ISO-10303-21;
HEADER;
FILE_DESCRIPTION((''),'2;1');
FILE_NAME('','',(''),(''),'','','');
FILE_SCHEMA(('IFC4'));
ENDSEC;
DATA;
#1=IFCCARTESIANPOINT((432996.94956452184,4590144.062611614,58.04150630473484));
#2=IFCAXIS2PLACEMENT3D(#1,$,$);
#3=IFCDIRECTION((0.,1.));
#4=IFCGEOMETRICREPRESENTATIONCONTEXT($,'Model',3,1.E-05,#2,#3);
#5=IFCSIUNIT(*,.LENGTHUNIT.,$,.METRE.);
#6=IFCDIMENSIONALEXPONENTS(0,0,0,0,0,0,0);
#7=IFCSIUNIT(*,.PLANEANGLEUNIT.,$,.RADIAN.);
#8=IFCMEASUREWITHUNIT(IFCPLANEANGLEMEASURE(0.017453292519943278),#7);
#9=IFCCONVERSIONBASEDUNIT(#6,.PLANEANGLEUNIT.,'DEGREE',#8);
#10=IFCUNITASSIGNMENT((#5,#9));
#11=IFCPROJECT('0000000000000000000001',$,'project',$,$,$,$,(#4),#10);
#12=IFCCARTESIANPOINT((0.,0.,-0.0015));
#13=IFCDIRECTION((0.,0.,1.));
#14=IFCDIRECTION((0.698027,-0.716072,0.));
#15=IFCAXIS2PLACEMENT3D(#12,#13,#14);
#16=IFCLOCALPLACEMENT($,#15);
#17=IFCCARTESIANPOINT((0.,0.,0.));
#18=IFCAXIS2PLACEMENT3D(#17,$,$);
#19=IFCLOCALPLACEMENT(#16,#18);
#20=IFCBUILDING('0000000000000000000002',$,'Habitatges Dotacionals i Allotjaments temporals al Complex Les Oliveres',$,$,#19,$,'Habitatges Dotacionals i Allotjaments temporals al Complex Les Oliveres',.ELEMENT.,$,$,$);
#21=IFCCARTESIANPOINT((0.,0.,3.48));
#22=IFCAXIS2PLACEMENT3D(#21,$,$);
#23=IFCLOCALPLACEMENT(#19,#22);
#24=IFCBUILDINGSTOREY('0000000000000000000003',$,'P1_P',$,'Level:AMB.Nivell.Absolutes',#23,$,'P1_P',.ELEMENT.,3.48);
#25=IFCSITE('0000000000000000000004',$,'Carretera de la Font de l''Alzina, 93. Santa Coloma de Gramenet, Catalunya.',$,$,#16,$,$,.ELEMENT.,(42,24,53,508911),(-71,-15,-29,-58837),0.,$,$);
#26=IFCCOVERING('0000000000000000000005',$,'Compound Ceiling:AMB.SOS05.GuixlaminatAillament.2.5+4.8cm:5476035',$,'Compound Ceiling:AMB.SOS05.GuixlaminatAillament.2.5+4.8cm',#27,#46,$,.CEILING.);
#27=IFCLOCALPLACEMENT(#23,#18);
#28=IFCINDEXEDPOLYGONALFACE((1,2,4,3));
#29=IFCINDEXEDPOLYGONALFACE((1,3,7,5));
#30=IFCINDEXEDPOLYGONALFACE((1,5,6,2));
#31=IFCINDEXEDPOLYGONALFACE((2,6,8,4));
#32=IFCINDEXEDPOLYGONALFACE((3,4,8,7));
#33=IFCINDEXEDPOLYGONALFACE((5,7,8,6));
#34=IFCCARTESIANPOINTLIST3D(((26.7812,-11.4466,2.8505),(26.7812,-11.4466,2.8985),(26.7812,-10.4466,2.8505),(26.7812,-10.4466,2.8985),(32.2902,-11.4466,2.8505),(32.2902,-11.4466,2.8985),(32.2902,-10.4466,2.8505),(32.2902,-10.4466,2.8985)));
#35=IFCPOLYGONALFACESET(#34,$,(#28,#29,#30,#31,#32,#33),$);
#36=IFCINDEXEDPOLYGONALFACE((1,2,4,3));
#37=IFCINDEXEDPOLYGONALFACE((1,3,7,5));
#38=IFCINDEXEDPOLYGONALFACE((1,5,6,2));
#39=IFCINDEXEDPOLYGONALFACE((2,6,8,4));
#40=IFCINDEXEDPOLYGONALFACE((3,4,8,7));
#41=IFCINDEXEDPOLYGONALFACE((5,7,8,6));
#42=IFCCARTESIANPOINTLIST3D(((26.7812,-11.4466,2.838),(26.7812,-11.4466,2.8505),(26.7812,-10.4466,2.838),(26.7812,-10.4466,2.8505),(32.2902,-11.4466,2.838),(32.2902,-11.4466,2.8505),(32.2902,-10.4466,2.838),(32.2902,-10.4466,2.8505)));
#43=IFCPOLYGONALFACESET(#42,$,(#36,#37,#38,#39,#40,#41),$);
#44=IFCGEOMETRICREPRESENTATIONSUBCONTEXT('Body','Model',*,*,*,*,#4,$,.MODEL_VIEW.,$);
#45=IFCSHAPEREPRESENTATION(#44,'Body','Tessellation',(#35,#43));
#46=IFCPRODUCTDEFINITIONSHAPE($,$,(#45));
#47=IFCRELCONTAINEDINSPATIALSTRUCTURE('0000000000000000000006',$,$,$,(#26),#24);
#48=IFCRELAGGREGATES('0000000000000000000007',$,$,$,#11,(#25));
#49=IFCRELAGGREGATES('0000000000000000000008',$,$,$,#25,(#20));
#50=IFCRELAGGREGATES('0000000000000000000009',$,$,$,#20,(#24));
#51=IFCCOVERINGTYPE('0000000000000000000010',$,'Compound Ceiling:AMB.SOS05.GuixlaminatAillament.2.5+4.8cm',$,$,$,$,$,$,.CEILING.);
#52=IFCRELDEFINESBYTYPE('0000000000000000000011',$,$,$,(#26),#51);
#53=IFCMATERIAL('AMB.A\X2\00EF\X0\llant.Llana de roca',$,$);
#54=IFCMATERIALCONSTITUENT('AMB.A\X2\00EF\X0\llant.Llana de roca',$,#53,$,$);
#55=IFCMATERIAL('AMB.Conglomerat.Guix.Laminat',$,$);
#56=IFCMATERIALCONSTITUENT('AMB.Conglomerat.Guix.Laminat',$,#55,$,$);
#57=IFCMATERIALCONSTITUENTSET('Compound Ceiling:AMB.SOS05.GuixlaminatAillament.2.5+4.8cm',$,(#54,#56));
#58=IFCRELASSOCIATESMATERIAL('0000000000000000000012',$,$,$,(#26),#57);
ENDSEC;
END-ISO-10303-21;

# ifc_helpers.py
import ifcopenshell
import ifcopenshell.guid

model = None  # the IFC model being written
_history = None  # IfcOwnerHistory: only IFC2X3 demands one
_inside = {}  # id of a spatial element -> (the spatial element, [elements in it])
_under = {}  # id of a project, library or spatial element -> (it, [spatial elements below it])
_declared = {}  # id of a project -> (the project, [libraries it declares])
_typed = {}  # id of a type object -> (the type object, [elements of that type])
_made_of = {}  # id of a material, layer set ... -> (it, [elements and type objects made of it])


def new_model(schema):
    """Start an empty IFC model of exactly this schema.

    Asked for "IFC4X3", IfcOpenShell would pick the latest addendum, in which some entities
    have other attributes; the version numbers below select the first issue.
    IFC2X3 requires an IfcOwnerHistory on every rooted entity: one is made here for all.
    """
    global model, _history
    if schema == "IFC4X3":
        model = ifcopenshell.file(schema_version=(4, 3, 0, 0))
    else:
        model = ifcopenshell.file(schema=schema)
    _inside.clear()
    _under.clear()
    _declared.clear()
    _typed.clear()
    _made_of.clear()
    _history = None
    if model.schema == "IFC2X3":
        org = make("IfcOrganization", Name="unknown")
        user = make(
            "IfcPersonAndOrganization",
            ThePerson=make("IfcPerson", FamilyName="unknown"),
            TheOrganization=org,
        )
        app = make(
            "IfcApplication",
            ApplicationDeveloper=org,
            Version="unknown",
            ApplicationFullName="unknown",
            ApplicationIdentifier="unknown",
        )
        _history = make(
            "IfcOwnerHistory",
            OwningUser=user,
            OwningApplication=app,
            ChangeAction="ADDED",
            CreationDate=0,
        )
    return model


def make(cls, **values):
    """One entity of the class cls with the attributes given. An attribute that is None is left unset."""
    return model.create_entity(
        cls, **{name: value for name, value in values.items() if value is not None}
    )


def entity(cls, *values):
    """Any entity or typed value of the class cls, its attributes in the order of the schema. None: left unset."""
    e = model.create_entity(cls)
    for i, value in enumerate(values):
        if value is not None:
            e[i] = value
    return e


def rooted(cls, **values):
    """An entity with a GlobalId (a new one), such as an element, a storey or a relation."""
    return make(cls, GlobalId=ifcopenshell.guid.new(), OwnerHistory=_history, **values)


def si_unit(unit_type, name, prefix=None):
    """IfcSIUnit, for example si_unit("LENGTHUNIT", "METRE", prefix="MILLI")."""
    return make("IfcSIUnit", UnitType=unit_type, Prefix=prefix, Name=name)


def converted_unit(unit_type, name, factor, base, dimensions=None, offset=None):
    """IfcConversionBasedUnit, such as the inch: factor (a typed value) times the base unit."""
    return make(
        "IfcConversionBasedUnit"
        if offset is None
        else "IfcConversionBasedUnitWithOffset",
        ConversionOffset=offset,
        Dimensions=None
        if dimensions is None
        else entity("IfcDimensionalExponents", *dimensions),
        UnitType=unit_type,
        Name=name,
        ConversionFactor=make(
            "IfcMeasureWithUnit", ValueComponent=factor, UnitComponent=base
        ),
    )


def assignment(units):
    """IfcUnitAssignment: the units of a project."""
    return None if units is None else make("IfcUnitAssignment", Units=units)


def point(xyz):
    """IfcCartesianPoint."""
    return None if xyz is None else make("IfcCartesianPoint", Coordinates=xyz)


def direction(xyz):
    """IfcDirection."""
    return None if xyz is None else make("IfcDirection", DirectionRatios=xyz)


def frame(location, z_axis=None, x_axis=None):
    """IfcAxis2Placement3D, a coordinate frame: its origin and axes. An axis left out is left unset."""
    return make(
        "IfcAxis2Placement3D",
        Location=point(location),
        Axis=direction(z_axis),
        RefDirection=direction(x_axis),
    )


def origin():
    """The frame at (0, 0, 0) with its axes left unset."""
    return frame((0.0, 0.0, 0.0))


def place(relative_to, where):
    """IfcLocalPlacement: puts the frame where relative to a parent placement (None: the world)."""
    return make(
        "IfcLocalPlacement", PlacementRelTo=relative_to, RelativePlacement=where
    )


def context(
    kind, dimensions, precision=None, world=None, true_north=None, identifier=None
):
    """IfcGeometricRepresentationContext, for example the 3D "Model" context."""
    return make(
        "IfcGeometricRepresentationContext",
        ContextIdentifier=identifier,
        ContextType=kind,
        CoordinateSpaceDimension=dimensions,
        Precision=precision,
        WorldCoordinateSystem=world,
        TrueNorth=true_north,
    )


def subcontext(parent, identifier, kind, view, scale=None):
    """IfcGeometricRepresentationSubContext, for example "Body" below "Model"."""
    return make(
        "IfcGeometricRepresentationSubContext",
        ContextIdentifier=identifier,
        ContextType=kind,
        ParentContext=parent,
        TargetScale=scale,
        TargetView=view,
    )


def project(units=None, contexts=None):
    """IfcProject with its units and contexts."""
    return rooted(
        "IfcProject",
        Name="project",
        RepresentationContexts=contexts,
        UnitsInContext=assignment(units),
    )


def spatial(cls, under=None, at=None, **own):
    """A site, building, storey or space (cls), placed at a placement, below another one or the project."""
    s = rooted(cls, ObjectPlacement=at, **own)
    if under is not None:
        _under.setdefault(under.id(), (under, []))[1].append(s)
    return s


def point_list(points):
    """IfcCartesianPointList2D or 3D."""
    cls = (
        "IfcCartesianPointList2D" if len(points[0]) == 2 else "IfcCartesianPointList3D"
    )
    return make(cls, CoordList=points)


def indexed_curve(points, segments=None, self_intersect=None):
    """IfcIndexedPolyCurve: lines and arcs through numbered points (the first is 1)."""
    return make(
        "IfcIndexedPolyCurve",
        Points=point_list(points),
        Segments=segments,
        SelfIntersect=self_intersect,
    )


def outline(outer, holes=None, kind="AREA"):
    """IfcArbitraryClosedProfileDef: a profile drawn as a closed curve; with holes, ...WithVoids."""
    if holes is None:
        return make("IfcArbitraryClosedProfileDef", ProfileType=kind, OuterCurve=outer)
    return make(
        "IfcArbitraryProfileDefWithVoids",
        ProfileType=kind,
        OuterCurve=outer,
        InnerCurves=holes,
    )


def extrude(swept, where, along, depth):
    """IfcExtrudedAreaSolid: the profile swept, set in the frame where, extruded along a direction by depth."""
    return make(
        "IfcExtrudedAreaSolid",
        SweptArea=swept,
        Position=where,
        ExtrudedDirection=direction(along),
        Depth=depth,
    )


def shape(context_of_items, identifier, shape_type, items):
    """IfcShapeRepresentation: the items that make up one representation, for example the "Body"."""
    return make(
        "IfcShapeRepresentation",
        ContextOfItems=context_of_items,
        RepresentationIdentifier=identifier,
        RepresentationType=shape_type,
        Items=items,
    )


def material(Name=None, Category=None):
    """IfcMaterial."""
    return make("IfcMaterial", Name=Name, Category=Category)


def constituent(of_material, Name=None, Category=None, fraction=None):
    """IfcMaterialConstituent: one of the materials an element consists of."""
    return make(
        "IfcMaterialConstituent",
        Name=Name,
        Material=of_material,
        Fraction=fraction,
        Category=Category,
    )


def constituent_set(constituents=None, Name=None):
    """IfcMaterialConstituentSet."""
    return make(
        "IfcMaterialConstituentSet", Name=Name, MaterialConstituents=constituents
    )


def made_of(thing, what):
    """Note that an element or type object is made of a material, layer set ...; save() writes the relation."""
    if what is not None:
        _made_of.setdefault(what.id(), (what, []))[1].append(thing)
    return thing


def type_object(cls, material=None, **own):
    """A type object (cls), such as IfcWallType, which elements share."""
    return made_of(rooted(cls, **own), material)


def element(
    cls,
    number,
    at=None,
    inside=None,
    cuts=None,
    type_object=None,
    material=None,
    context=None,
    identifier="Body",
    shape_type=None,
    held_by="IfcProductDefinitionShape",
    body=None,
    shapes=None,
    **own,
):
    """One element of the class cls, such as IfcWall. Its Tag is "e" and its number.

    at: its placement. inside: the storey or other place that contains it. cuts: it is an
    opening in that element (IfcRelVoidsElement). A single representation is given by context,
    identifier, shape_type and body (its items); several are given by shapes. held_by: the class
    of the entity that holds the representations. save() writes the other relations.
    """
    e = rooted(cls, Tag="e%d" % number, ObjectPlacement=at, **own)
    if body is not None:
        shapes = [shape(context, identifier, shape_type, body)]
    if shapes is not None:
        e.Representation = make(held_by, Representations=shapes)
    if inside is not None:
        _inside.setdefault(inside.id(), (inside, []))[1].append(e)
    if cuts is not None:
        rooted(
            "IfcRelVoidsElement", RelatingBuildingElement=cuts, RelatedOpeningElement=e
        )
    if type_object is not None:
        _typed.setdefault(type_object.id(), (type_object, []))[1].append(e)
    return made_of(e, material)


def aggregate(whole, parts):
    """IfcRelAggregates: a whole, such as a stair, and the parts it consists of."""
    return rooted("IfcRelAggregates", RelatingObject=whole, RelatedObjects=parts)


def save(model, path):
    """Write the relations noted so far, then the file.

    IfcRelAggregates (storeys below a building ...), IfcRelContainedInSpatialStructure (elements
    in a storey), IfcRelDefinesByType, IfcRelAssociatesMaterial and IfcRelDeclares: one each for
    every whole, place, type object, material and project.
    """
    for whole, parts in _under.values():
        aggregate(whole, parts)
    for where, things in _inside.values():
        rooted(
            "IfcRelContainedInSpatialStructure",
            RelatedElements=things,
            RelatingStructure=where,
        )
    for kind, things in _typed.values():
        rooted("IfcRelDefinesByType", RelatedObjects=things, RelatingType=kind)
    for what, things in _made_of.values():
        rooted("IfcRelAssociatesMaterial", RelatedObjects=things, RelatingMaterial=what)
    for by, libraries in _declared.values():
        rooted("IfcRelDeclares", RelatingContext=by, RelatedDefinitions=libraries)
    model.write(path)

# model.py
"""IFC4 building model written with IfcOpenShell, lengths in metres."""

from ifc_helpers import new_model, entity, si_unit, converted_unit, direction, frame, origin, place, context, subcontext, project, spatial, indexed_curve, outline, extrude, material, constituent, constituent_set, type_object, element, save


model = new_model("IFC4")

# Units and contexts
model_context = context("Model", 3, precision=1e-05, world=frame((432996.94956452184, 4590144.062611614, 58.04150630473484)), true_north=direction((0.0, 1.0)))
body_context = subcontext(model_context, "Body", "Model", "MODEL_VIEW")
ifc_project = project(units=[si_unit("LENGTHUNIT", "METRE"), converted_unit("PLANEANGLEUNIT", "DEGREE", entity("IfcPlaneAngleMeasure", 0.017453292519943278), si_unit("PLANEANGLEUNIT", "RADIAN"), dimensions=[0, 0, 0, 0, 0, 0, 0])], contexts=[model_context])

# Site, building, storey
site_placement = place(None, frame((0.0, 0.0, -0.0015), z_axis=(0.0, 0.0, 1.0), x_axis=(0.698027, -0.716072, 0.0)))
site = spatial("IfcSite", under=ifc_project, at=site_placement, Name="Carretera de la Font de l'Alzina, 93. Santa Coloma de Gramenet, Catalunya.", CompositionType="ELEMENT", RefLatitude=(42, 24, 53, 508911), RefLongitude=(-71, -15, -29, -58837), RefElevation=0.0)
building_placement = place(site_placement, origin())
building = spatial("IfcBuilding", under=site, at=building_placement, Name="Habitatges Dotacionals i Allotjaments temporals al Complex Les Oliveres", LongName="Habitatges Dotacionals i Allotjaments temporals al Complex Les Oliveres", CompositionType="ELEMENT")
storey_placement = place(building_placement, frame((0.0, 0.0, 3.48)))
storey = spatial("IfcBuildingStorey", under=building, at=storey_placement, Name="P1_P", ObjectType="Level:AMB.Nivell.Absolutes", LongName="P1_P", CompositionType="ELEMENT", Elevation=3.48)

# Covering
ifc_material_1 = material(Name="AMB.Aïllant.Llana de roca")
ifc_constituent_1 = constituent(ifc_material_1, Name="AMB.Aïllant.Llana de roca")
ifc_material_2 = material(Name="AMB.Conglomerat.Guix.Laminat")
ifc_constituent_2 = constituent(ifc_material_2, Name="AMB.Conglomerat.Guix.Laminat")
ifc_constituent_set_1 = constituent_set(constituents=[ifc_constituent_1, ifc_constituent_2], Name="Compound Ceiling:AMB.SOS05.GuixlaminatAillament.2.5+4.8cm")
covering_type_1 = type_object("IfcCoveringType", Name="Compound Ceiling:AMB.SOS05.GuixlaminatAillament.2.5+4.8cm", PredefinedType="CEILING")
covering_1_placement = place(storey_placement, origin())
element("IfcCovering", 1, at=covering_1_placement, inside=storey, type_object=covering_type_1, material=ifc_constituent_set_1, Name="Compound Ceiling:AMB.SOS05.GuixlaminatAillament.2.5+4.8cm:5476035", ObjectType="Compound Ceiling:AMB.SOS05.GuixlaminatAillament.2.5+4.8cm", PredefinedType="CEILING", context=body_context, shape_type="SweptSolid", body=[
    extrude(outline(indexed_curve([(-2.7545, -0.5), (2.7545, -0.5), (2.7545, 0.5), (-2.7545, 0.5), (-2.7545, -0.5)], self_intersect=False)), frame((29.5357, -10.9466, 2.8505)), (0.0, 0.0, 1.0), 0.048),
    extrude(outline(indexed_curve([(-0.5, -2.7545), (0.5, -2.7545), (0.5, 2.7545), (-0.5, 2.7545), (-0.5, -2.7545)], self_intersect=False)), frame((29.5357, -10.9466, 2.838), z_axis=(0.0, 0.0, 1.0), x_axis=(0.0, 1.0, 0.0)), (0.0, 0.0, 1.0), 0.0125),
])

save(model, "model.ifc")
